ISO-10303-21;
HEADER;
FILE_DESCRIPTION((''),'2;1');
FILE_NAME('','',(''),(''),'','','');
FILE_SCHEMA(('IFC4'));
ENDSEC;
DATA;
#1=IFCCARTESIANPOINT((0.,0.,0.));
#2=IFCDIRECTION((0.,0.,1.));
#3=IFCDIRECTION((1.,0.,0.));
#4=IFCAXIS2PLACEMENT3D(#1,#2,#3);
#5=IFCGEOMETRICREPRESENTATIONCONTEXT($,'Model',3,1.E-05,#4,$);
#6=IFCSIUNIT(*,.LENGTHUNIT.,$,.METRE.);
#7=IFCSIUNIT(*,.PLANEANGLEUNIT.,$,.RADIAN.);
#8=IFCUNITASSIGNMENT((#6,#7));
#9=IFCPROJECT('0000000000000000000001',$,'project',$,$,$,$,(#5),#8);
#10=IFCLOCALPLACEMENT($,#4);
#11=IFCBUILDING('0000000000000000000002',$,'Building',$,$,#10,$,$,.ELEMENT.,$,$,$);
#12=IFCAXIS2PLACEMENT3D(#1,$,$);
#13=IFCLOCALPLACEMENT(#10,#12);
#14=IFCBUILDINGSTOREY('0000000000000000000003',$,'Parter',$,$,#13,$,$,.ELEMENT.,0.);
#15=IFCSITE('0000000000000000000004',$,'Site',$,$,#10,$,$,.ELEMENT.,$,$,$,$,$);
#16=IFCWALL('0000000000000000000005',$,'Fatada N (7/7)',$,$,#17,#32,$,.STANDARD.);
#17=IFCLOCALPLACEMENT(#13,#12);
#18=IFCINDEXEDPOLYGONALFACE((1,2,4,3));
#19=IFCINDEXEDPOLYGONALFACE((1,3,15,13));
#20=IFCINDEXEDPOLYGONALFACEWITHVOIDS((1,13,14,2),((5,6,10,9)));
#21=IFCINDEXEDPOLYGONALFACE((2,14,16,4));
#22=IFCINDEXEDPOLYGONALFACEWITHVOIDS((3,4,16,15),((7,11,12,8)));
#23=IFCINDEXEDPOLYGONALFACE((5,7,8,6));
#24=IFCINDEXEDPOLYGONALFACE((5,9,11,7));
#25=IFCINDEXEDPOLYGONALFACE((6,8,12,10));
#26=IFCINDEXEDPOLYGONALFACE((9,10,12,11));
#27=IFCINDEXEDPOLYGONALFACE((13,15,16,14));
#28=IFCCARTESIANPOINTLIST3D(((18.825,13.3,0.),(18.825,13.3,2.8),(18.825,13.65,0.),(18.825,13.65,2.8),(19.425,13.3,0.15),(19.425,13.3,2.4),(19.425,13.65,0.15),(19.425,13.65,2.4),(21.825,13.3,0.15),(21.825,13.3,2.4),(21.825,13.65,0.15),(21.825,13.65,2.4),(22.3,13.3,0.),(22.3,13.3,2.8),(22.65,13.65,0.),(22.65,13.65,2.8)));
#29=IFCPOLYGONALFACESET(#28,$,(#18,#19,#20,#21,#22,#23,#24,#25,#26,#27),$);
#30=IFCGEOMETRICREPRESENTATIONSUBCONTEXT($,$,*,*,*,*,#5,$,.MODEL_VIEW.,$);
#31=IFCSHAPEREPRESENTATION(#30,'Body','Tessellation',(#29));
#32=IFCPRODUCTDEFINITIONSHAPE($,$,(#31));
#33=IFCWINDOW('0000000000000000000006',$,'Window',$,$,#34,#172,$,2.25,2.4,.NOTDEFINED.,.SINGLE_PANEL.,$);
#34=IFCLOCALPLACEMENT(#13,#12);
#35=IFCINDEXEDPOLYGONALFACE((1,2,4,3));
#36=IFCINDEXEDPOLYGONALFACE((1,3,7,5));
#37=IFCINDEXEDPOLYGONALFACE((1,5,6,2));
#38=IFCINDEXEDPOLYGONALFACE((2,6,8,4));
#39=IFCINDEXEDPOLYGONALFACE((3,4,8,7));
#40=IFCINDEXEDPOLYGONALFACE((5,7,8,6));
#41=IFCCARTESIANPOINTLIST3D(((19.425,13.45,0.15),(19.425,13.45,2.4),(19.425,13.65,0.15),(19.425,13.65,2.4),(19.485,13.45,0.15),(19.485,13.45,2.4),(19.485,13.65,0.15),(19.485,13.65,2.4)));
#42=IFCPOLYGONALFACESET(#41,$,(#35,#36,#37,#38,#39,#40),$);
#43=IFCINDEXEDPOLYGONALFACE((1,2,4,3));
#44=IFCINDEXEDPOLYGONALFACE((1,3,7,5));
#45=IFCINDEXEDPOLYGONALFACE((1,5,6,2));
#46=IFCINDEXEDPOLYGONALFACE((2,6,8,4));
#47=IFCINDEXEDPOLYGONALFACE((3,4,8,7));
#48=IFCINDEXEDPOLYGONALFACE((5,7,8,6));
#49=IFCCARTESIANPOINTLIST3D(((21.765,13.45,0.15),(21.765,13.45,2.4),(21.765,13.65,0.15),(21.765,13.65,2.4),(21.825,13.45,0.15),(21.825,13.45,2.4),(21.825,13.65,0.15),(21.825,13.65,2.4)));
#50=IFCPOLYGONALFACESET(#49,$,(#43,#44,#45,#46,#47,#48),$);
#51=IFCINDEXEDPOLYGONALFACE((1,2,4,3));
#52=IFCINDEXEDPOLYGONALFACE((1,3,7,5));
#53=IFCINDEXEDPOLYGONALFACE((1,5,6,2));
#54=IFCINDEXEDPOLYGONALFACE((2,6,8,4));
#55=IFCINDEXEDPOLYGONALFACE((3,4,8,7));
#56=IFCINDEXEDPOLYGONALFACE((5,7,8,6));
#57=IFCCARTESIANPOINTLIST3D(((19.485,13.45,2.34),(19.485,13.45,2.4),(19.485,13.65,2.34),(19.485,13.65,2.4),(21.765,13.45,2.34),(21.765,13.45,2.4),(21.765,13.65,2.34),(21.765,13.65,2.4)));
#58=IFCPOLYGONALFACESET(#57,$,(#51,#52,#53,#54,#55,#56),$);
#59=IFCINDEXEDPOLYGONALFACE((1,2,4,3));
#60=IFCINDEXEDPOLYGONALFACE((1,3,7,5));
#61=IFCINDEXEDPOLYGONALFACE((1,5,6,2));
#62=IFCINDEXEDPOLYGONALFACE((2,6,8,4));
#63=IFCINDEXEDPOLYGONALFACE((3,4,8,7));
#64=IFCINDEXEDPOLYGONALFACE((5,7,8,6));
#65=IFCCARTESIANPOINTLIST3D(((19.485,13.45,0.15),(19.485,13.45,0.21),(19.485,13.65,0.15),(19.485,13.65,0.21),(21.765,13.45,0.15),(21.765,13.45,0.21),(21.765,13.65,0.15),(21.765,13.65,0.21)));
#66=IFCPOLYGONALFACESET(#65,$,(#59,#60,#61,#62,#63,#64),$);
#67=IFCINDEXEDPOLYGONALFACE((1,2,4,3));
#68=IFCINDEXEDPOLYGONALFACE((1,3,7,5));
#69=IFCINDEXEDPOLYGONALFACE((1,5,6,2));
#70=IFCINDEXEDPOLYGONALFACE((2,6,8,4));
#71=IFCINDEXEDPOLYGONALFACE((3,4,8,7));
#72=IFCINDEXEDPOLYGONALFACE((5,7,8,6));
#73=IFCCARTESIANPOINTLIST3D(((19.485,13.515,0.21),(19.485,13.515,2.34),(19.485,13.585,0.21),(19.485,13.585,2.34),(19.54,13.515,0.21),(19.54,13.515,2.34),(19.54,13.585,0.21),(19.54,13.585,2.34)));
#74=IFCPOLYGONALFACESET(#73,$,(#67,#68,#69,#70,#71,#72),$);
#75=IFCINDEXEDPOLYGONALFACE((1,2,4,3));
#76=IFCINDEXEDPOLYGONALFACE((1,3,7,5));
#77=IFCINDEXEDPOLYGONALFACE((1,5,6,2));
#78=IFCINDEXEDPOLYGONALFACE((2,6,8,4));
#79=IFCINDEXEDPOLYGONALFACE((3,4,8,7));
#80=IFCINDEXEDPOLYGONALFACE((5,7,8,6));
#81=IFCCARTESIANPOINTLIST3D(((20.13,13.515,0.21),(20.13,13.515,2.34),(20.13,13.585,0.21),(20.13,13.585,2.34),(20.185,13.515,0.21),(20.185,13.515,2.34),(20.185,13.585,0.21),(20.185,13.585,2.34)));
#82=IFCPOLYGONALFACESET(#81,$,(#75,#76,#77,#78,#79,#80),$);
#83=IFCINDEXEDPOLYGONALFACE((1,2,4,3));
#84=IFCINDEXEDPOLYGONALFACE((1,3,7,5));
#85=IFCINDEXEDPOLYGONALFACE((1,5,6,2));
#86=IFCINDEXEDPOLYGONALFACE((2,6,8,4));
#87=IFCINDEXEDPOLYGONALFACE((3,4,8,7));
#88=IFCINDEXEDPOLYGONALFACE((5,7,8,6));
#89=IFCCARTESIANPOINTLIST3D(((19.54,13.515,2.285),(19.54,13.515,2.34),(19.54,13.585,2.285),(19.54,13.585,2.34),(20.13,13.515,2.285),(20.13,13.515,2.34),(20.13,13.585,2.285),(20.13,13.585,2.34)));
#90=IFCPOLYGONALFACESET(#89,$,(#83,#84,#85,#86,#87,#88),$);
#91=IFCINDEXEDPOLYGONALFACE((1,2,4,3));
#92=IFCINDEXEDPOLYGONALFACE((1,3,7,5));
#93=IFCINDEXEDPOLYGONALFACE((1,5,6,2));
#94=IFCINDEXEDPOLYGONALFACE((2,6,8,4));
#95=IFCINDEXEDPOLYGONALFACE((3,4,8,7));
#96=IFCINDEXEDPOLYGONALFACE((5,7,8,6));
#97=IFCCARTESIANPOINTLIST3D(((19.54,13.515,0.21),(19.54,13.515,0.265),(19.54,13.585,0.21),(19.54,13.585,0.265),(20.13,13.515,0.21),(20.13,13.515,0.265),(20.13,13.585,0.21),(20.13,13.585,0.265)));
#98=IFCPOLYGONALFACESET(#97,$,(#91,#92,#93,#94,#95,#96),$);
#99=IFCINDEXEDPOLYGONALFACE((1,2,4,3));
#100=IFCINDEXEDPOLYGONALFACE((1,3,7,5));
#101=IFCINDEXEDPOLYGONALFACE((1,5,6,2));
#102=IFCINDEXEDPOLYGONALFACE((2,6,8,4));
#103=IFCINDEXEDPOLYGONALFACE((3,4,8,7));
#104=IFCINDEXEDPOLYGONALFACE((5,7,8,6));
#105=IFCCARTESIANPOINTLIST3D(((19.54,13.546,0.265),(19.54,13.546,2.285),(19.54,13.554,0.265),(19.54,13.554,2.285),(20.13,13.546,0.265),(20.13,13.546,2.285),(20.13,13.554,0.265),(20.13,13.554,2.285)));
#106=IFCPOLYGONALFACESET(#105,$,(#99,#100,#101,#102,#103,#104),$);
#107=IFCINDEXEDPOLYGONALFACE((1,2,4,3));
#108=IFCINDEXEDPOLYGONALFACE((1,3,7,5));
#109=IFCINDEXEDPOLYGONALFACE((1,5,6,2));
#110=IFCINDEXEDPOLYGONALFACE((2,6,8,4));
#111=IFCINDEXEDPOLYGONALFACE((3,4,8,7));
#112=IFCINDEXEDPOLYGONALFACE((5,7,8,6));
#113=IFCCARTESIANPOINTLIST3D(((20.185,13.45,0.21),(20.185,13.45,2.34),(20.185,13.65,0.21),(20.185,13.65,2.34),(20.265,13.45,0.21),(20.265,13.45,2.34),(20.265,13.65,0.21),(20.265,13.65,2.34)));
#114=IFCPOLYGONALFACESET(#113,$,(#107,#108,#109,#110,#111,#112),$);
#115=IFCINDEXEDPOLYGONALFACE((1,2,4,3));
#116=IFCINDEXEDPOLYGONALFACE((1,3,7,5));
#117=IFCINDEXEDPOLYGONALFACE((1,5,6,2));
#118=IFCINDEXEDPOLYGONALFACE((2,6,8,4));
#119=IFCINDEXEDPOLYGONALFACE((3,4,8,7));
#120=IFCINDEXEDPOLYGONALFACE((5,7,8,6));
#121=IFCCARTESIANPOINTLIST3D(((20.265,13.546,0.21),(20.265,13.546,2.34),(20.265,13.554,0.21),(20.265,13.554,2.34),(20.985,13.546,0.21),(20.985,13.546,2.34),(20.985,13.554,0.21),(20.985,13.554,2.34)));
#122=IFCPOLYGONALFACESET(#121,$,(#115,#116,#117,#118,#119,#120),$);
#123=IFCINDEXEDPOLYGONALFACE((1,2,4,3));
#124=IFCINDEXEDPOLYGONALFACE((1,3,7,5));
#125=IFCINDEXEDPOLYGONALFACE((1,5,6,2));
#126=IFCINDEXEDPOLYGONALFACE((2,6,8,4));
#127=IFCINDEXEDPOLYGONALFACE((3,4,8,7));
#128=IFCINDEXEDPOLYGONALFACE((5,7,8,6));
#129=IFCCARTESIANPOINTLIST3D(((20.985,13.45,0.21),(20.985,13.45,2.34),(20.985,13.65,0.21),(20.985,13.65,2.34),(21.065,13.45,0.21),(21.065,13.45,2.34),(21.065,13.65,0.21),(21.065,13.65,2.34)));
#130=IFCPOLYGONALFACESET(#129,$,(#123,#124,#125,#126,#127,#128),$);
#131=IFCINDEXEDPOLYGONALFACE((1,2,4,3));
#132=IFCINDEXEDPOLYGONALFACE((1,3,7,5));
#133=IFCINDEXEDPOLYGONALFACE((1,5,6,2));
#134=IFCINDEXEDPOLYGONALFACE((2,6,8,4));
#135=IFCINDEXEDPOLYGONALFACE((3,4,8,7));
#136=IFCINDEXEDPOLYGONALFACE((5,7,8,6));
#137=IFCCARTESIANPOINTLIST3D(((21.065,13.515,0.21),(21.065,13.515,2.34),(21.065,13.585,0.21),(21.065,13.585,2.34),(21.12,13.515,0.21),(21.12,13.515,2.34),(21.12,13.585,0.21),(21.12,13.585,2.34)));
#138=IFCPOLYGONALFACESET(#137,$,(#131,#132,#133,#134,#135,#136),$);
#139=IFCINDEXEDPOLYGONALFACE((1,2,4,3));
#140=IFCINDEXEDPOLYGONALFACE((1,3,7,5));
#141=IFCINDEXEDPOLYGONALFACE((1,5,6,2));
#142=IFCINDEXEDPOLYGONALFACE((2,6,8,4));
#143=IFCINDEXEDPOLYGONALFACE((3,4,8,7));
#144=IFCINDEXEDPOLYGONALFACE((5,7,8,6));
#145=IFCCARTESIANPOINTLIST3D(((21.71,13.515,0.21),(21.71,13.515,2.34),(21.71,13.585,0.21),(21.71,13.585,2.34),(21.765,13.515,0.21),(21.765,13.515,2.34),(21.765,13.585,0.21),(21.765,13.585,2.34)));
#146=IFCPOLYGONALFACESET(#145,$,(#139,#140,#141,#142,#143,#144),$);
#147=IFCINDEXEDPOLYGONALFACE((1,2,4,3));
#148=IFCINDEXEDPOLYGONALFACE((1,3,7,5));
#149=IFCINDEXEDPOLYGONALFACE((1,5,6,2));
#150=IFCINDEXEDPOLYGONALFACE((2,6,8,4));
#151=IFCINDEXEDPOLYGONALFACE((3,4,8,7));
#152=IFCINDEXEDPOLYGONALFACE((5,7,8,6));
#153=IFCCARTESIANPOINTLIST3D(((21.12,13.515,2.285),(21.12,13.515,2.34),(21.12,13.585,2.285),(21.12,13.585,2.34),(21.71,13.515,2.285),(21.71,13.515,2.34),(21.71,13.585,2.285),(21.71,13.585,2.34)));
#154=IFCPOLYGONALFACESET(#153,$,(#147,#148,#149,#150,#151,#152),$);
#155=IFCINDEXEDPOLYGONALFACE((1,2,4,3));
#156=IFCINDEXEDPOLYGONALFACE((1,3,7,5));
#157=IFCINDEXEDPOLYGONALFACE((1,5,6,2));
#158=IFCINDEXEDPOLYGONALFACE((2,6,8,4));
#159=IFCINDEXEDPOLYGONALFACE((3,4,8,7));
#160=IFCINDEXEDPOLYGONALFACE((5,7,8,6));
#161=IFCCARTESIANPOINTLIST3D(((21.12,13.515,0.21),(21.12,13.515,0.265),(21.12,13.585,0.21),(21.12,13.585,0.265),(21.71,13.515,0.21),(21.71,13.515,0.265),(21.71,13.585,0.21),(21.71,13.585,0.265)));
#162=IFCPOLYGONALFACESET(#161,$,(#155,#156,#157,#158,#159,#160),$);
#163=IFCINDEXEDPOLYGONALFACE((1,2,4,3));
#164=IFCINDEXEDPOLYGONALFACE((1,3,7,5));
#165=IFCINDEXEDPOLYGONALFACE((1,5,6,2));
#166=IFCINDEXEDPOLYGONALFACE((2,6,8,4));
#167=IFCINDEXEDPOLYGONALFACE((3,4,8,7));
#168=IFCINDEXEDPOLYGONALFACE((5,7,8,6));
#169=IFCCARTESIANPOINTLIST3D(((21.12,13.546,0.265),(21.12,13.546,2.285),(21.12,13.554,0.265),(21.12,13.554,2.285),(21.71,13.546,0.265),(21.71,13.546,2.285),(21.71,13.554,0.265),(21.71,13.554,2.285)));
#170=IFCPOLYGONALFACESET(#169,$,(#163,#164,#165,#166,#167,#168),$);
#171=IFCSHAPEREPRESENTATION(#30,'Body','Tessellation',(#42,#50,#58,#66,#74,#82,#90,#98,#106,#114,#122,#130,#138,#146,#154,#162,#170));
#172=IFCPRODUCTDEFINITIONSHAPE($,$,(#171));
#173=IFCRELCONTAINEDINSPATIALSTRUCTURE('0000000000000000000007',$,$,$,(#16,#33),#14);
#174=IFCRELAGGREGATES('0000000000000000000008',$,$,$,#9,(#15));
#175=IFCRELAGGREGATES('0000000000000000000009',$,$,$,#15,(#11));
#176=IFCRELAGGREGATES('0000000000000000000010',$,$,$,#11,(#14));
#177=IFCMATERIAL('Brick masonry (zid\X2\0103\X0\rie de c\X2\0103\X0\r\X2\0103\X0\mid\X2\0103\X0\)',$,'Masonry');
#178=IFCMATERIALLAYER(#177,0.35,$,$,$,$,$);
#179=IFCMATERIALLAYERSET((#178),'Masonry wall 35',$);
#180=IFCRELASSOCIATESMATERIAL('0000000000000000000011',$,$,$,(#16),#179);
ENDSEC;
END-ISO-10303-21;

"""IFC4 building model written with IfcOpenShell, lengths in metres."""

from ifc_helpers import new_model, si_unit, frame, frame_2d, origin, origin_with_axes, origin_2d, place, context, subcontext, project, spatial, rectangle, extrude, clip, halfspace, material, layer, layer_set, layer_usage, element, fill, save


model = new_model("IFC4")

# Units and contexts
model_context = context("Model", 3, precision=1e-05, world=origin_with_axes())
sub_context = subcontext(model_context, None, None, "MODEL_VIEW")
ifc_project = project(units=[si_unit("LENGTHUNIT", "METRE"), si_unit("PLANEANGLEUNIT", "RADIAN")], contexts=[model_context])

# Site, building, storey
placement = place(None, origin_with_axes())
site = spatial("IfcSite", under=ifc_project, at=placement, Name="Site", CompositionType="ELEMENT")
building = spatial("IfcBuilding", under=site, at=placement, Name="Building", CompositionType="ELEMENT")
storey_placement = place(placement, origin())
storey = spatial("IfcBuildingStorey", under=building, at=storey_placement, Name="Parter", CompositionType="ELEMENT", Elevation=0.0)

# Wall, opening, window
ifc_material_1 = material(Name="Brick masonry (zidărie de cărămidă)", Category="Masonry")
ifc_layer_1 = layer(ifc_material_1, 0.35)
ifc_layer_set_1 = layer_set([ifc_layer_1], Name="Masonry wall 35")
ifc_layer_usage_1 = layer_usage(ifc_layer_set_1, "AXIS2", "POSITIVE", -0.175)
wall_1_placement = place(storey_placement, frame((18.825, 13.475, 0.0), x_axis=(1.0, 0.0, 0.0)))
wall_1 = element("IfcWall", 1, at=wall_1_placement, inside=storey, material=ifc_layer_usage_1, Name="Fatada N (7/7)", PredefinedType="STANDARD", context=sub_context, shape_type="CSG", body=[
    clip(extrude(rectangle(XDim=3.825, YDim=0.35, at=frame_2d((1.9125, 0.0))), origin(), (0.0, 0.0, 1.0), 2.8), halfspace(frame((3.65, 0.0, 0.0), z_axis=(0.707107, -0.707107, 0.0)), False)),
])
opening_1_placement = place(wall_1_placement, frame((1.8, 0.225, 0.15), z_axis=(0.0, -1.0, 0.0), x_axis=(1.0, 0.0, 0.0)))
opening_1 = element("IfcOpeningElement", 2, at=opening_1_placement, cuts=wall_1, PredefinedType="OPENING", context=sub_context, shape_type="SweptSolid", body=[
    extrude(rectangle(XDim=2.4, YDim=2.25, at=frame_2d((0.0, 1.125))), origin(), (0.0, 0.0, 1.0), 0.45),
])
window_1_placement = place(wall_1_placement, frame((1.8, 0.175, 0.15), z_axis=(0.0, -1.0, 0.0), x_axis=(1.0, 0.0, 0.0)))
window_1 = element("IfcWindow", 3, at=window_1_placement, inside=storey, Name="Window", OverallHeight=2.25, OverallWidth=2.4, PartitioningType="SINGLE_PANEL", PredefinedType="NOTDEFINED", context=sub_context, shape_type="SweptSolid", body=[
    extrude(rectangle(XDim=0.06, YDim=2.25, at=origin_2d()), frame((-1.17, 1.125, 0.0)), (0.0, 0.0, 1.0), 0.2),
    extrude(rectangle(XDim=0.06, YDim=2.25, at=origin_2d()), frame((1.17, 1.125, 0.0)), (0.0, 0.0, 1.0), 0.2),
    extrude(rectangle(XDim=2.28, YDim=0.06, at=origin_2d()), frame((0.0, 2.22, 0.0)), (0.0, 0.0, 1.0), 0.2),
    extrude(rectangle(XDim=2.28, YDim=0.06, at=origin_2d()), frame((0.0, 0.03, 0.0)), (0.0, 0.0, 1.0), 0.2),
    extrude(rectangle(XDim=0.055, YDim=2.13, at=origin_2d()), frame((-1.1125, 1.125, 0.065)), (0.0, 0.0, 1.0), 0.07),
    extrude(rectangle(XDim=0.055, YDim=2.13, at=origin_2d()), frame((-0.4675, 1.125, 0.065)), (0.0, 0.0, 1.0), 0.07),
    extrude(rectangle(XDim=0.59, YDim=0.055, at=origin_2d()), frame((-0.79, 2.1625, 0.065)), (0.0, 0.0, 1.0), 0.07),
    extrude(rectangle(XDim=0.59, YDim=0.055, at=origin_2d()), frame((-0.79, 0.0875, 0.065)), (0.0, 0.0, 1.0), 0.07),
    extrude(rectangle(XDim=0.59, YDim=2.02, at=origin_2d()), frame((-0.79, 1.125, 0.096)), (0.0, 0.0, 1.0), 0.008),
    extrude(rectangle(XDim=0.08, YDim=2.13, at=origin_2d()), frame((-0.4, 1.125, 0.0)), (0.0, 0.0, 1.0), 0.2),
    extrude(rectangle(XDim=0.72, YDim=2.13, at=origin_2d()), frame((0.0, 1.125, 0.096)), (0.0, 0.0, 1.0), 0.008),
    extrude(rectangle(XDim=0.08, YDim=2.13, at=origin_2d()), frame((0.4, 1.125, 0.0)), (0.0, 0.0, 1.0), 0.2),
    extrude(rectangle(XDim=0.055, YDim=2.13, at=origin_2d()), frame((0.4675, 1.125, 0.065)), (0.0, 0.0, 1.0), 0.07),
    extrude(rectangle(XDim=0.055, YDim=2.13, at=origin_2d()), frame((1.1125, 1.125, 0.065)), (0.0, 0.0, 1.0), 0.07),
    extrude(rectangle(XDim=0.59, YDim=0.055, at=origin_2d()), frame((0.79, 2.1625, 0.065)), (0.0, 0.0, 1.0), 0.07),
    extrude(rectangle(XDim=0.59, YDim=0.055, at=origin_2d()), frame((0.79, 0.0875, 0.065)), (0.0, 0.0, 1.0), 0.07),
    extrude(rectangle(XDim=0.59, YDim=2.02, at=origin_2d()), frame((0.79, 1.125, 0.096)), (0.0, 0.0, 1.0), 0.008),
])
fill(opening_1, window_1)

save(model, "model.ifc")
